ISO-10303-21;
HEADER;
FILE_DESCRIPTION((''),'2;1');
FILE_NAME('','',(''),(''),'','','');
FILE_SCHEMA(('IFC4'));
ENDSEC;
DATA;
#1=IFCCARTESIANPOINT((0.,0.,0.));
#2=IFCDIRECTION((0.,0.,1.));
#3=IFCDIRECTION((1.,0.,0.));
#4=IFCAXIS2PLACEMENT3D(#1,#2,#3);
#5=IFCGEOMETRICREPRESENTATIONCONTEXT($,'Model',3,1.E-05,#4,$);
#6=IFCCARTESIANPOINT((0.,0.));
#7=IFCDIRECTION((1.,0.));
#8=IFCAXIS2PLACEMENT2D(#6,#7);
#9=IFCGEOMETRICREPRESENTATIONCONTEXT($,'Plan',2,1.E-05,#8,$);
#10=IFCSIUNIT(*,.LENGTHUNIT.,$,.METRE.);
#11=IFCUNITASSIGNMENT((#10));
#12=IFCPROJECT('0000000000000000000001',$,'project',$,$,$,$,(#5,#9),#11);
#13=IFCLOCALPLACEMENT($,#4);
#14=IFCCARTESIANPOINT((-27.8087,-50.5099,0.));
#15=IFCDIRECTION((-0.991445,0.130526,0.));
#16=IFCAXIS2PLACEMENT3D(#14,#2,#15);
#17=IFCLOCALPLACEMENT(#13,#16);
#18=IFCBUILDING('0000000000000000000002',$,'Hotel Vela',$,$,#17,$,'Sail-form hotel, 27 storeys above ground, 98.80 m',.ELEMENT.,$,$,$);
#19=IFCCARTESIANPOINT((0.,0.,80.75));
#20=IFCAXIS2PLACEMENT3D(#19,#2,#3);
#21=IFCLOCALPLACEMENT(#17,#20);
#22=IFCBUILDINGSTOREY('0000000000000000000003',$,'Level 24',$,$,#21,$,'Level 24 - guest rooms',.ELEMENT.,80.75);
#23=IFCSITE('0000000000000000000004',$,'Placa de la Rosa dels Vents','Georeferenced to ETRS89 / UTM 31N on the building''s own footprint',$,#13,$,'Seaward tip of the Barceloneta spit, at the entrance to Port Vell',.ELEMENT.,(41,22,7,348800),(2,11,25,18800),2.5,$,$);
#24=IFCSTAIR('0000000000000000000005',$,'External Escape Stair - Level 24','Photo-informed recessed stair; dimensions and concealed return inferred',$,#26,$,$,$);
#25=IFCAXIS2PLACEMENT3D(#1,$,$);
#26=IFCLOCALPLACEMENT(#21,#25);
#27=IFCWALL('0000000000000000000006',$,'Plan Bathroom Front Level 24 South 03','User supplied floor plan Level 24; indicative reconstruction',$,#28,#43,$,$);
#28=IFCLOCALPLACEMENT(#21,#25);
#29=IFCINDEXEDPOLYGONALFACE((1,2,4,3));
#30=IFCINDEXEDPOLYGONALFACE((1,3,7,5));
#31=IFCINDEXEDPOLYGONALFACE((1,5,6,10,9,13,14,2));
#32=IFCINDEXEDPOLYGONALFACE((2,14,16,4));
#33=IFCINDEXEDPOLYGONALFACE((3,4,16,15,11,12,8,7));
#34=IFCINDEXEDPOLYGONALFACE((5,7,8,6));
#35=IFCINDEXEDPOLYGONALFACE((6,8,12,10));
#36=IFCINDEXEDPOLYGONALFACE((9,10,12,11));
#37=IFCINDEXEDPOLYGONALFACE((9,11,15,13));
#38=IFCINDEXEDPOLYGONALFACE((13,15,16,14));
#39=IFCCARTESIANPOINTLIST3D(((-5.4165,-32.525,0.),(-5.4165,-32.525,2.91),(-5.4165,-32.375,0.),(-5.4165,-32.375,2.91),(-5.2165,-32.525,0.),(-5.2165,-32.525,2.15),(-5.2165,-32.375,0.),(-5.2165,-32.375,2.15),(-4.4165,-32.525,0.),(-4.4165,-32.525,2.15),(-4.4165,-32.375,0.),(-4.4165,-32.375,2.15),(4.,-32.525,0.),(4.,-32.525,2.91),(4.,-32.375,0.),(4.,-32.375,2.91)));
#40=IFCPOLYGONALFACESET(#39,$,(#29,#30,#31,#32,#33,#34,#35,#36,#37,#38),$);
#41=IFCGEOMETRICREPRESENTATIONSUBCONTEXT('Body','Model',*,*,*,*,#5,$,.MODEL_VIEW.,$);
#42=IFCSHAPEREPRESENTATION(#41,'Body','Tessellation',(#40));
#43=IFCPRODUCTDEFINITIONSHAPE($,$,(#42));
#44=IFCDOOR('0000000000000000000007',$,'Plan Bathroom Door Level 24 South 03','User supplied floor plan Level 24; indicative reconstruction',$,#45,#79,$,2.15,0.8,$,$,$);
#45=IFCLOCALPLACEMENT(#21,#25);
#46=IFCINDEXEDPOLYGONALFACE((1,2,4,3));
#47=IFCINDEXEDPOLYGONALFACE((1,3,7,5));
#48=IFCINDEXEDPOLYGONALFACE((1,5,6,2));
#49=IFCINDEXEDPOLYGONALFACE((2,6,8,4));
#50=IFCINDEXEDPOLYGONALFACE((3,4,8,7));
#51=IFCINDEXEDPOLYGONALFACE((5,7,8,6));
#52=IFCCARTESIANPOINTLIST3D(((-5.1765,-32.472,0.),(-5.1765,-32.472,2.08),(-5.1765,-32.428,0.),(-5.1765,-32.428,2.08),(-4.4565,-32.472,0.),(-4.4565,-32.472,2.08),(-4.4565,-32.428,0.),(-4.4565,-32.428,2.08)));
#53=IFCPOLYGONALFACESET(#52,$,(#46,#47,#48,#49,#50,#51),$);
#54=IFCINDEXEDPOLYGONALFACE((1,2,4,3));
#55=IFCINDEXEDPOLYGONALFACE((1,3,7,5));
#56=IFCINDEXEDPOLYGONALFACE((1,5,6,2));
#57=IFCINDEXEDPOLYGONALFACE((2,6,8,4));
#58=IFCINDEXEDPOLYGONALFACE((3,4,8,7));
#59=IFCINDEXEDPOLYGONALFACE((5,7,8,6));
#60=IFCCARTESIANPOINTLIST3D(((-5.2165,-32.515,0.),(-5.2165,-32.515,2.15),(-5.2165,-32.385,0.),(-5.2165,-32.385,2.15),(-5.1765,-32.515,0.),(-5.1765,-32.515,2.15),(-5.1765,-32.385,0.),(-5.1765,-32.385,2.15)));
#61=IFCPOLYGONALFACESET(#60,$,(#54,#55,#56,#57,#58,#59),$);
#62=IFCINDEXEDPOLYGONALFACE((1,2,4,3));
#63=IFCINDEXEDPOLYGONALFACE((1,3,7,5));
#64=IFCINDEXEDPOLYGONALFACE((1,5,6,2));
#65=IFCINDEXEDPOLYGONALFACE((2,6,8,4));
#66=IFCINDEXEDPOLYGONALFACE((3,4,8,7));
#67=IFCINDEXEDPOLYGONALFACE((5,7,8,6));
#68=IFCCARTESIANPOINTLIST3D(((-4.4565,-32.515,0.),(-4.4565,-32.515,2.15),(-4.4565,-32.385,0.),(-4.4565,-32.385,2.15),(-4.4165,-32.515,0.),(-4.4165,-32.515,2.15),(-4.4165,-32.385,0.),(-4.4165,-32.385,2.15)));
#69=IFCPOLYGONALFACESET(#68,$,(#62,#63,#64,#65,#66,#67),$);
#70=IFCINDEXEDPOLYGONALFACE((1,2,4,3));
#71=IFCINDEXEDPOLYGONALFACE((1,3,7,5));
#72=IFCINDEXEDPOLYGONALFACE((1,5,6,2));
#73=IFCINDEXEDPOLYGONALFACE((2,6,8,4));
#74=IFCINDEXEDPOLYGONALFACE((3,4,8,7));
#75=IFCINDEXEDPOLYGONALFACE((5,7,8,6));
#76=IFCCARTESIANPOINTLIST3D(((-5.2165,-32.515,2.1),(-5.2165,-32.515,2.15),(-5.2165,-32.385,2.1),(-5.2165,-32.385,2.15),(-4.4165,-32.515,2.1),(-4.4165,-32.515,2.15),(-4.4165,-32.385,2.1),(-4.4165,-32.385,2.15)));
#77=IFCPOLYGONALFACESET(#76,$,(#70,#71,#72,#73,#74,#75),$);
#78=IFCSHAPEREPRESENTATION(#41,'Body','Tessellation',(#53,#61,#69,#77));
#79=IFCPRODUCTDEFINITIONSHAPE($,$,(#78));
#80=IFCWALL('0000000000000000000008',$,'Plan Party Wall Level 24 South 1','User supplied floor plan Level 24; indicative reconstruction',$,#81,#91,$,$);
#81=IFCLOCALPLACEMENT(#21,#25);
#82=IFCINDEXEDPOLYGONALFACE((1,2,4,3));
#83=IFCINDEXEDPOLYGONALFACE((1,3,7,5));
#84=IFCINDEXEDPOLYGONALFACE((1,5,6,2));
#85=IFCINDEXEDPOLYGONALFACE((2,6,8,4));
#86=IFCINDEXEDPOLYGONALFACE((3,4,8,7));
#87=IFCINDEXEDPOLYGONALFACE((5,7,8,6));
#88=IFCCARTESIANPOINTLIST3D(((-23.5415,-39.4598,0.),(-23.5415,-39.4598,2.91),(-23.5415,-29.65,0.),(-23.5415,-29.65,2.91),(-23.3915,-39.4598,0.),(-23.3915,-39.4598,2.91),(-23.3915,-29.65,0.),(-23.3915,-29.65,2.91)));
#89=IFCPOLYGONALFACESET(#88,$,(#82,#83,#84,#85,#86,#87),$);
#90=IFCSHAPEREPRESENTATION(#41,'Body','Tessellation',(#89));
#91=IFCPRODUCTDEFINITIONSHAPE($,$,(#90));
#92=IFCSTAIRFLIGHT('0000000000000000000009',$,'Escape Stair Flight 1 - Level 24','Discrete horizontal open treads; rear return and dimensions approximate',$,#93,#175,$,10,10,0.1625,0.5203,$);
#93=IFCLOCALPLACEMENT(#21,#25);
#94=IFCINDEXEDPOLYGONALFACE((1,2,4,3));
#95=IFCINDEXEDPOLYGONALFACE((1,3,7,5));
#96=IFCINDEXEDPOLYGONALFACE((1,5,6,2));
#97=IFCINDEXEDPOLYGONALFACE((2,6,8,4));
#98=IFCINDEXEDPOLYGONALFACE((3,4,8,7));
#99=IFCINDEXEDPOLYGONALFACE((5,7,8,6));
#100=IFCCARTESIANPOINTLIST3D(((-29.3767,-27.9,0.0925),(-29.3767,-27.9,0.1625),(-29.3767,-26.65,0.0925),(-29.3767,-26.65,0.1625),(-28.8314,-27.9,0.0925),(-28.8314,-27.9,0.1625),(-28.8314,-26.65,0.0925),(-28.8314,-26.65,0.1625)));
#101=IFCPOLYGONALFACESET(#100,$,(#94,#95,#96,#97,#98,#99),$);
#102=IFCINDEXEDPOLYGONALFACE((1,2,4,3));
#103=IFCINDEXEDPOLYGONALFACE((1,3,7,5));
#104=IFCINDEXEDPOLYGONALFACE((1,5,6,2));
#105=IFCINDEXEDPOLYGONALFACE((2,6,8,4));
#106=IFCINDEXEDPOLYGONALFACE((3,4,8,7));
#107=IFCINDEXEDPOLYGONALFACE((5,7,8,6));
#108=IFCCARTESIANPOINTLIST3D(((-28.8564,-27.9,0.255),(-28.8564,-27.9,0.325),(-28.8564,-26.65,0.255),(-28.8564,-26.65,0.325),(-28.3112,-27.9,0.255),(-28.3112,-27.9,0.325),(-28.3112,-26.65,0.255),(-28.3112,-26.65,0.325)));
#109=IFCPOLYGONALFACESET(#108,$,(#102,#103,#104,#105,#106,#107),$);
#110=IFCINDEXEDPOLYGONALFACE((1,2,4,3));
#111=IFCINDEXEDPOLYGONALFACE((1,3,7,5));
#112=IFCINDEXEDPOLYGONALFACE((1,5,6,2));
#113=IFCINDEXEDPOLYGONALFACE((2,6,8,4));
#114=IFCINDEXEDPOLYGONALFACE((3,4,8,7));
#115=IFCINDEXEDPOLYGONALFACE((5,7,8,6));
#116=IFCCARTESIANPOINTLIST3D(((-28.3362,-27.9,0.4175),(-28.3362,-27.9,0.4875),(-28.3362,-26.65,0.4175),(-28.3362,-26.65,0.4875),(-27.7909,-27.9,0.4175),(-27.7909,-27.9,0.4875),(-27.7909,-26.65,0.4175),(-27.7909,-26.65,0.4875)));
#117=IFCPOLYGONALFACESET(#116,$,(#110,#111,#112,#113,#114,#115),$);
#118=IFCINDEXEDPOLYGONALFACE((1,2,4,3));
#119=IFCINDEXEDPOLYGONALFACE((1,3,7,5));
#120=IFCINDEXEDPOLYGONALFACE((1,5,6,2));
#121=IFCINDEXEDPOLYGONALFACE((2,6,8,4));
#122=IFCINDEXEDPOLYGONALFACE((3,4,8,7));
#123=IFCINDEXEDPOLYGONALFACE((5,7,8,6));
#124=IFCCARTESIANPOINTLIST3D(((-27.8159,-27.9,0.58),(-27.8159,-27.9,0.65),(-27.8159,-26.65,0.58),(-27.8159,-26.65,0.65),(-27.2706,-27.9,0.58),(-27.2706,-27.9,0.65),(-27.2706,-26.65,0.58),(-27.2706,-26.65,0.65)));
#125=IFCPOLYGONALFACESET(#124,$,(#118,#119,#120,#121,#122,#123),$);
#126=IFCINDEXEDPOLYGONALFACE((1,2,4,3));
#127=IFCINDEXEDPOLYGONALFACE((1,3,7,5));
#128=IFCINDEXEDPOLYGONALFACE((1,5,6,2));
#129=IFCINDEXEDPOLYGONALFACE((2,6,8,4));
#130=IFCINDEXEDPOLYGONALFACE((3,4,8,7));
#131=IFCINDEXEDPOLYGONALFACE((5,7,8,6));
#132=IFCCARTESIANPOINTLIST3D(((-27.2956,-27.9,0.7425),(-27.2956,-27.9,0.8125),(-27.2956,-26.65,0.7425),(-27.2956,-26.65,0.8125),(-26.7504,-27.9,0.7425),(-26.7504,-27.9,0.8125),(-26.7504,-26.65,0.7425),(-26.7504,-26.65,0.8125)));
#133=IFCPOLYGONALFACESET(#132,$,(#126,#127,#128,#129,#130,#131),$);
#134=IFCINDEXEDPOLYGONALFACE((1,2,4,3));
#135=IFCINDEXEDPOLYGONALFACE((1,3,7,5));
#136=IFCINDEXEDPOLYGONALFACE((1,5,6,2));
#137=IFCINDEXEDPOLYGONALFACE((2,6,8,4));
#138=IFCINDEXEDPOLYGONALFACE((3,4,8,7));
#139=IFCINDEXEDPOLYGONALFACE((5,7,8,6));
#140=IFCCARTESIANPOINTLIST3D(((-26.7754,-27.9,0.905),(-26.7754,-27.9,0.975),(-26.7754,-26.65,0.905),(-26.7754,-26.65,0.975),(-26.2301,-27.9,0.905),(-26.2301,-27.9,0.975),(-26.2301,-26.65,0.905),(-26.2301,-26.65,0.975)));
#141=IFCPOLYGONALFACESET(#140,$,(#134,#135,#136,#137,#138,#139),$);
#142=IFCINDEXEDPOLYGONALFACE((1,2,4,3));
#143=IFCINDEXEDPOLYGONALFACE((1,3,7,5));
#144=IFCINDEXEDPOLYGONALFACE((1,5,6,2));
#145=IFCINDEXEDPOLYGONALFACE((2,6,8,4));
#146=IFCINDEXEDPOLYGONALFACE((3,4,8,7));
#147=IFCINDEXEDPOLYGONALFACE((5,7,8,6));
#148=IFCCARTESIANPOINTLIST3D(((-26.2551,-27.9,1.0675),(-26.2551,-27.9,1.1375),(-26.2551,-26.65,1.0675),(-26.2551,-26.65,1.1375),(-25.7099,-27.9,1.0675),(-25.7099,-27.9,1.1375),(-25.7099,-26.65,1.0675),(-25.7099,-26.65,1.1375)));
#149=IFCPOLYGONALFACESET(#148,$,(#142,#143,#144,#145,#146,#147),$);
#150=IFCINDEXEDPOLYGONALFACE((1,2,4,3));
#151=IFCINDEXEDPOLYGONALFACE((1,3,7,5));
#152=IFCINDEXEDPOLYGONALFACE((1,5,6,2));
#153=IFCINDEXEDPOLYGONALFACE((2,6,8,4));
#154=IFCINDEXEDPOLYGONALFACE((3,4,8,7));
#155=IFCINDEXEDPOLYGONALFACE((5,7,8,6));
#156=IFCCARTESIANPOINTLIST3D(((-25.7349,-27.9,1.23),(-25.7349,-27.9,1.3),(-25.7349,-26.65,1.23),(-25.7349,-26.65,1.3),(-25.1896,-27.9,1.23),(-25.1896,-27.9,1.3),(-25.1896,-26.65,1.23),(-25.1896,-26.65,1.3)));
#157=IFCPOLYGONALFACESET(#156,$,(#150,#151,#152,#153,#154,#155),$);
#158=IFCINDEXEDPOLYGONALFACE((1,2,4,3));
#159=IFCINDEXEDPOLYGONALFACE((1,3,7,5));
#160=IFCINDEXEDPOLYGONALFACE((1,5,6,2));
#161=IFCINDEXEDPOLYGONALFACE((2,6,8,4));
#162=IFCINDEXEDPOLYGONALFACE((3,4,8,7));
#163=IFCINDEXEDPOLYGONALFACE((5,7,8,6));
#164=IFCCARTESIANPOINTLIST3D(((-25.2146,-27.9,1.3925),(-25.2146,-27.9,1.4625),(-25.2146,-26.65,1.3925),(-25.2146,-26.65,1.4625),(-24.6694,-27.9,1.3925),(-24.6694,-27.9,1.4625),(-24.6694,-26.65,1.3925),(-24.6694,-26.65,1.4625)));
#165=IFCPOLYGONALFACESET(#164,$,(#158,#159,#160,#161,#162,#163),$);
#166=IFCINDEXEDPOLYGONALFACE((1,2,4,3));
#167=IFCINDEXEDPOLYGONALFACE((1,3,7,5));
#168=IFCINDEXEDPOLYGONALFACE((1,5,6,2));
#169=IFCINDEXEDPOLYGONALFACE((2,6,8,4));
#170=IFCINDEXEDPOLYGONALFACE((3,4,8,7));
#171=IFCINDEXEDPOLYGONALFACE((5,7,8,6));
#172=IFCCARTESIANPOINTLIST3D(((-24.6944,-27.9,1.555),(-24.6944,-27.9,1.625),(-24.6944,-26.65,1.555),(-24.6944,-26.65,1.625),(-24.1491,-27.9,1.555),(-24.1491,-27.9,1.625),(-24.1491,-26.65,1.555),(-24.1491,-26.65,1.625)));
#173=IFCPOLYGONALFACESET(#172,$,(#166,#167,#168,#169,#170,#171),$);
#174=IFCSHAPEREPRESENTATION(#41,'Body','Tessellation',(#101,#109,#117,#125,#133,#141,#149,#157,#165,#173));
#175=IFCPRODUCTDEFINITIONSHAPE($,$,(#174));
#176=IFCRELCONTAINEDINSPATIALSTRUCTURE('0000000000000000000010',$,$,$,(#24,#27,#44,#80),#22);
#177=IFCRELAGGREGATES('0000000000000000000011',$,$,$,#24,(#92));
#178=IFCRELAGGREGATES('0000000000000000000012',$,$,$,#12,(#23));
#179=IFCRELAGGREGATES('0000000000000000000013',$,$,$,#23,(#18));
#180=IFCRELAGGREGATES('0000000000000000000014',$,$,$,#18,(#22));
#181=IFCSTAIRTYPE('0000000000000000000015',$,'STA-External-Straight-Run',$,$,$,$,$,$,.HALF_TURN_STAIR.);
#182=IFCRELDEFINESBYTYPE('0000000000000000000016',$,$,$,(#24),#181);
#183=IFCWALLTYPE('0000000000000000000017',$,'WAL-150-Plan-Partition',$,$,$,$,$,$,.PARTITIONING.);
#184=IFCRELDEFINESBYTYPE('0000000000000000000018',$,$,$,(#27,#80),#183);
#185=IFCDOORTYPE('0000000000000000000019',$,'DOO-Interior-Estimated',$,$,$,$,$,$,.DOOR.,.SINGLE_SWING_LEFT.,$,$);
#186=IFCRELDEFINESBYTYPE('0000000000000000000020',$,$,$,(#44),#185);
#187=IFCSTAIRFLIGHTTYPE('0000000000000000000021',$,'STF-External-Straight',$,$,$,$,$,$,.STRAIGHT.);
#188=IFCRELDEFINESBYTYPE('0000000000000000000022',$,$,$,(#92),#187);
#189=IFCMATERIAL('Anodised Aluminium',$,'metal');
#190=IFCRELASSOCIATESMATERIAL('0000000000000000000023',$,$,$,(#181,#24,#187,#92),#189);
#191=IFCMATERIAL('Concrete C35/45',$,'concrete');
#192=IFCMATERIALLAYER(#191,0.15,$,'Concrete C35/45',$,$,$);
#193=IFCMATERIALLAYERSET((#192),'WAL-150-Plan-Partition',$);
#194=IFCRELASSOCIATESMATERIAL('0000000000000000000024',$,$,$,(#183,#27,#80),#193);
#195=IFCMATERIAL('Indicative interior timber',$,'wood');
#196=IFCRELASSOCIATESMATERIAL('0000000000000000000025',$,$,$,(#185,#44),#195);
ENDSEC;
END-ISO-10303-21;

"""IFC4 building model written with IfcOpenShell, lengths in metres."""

from ifc_helpers import new_model, si_unit, frame, origin_with_axes, origin_2d_with_axis, place, context, subcontext, project, spatial, line, indexed_curve, outline, extrude, material, layer, layer_set, layer_usage, type_object, element, fill, aggregate, save


model = new_model("IFC4")

# Units and contexts
model_context = context("Model", 3, precision=1e-05, world=origin_with_axes())
plan_context = context("Plan", 2, precision=1e-05, world=origin_2d_with_axis())
body_context = subcontext(model_context, "Body", "Model", "MODEL_VIEW")
ifc_project = project(units=[si_unit("LENGTHUNIT", "METRE")], contexts=[model_context, plan_context])

# Site, building, storey
site_placement = place(None, origin_with_axes())
site = spatial("IfcSite", under=ifc_project, at=site_placement, Name="Placa de la Rosa dels Vents", Description="Georeferenced to ETRS89 / UTM 31N on the building's own footprint", LongName="Seaward tip of the Barceloneta spit, at the entrance to Port Vell", CompositionType="ELEMENT", RefLatitude=(41, 22, 7, 348800), RefLongitude=(2, 11, 25, 18800), RefElevation=2.5)
building_placement = place(site_placement, frame((-27.8087, -50.5099, 0.0), z_axis=(0.0, 0.0, 1.0), x_axis=(-0.991445, 0.130526, 0.0)))
building = spatial("IfcBuilding", under=site, at=building_placement, Name="Hotel Vela", LongName="Sail-form hotel, 27 storeys above ground, 98.80 m", CompositionType="ELEMENT")
storey_placement = place(building_placement, frame((0.0, 0.0, 80.75), z_axis=(0.0, 0.0, 1.0), x_axis=(1.0, 0.0, 0.0)))
storey = spatial("IfcBuildingStorey", under=building, at=storey_placement, Name="Level 24", LongName="Level 24 - guest rooms", CompositionType="ELEMENT", Elevation=80.75)

# Stair
ifc_material_1 = material(Name="Anodised Aluminium", Category="metal")
stair_type = type_object("IfcStairType", Name="STA-External-Straight-Run", PredefinedType="HALF_TURN_STAIR", material=ifc_material_1)
stair_placement = place(storey_placement, frame((0.0, 0.0, -80.75), z_axis=(0.0, 0.0, 1.0), x_axis=(1.0, 0.0, 0.0)))
stair = element("IfcStair", 1, at=stair_placement, inside=storey, type_object=stair_type, material=ifc_material_1, Name="External Escape Stair - Level 24", Description="Photo-informed recessed stair; dimensions and concealed return inferred")

# Shared definitions
ifc_material_2 = material(Name="Concrete C35/45", Category="concrete")

# Shared definitions
ifc_layer_1 = layer(ifc_material_2, 0.15, Name="Concrete C35/45")
ifc_layer_set_1 = layer_set([ifc_layer_1], Name="WAL-150-Plan-Partition")
wall_type = type_object("IfcWallType", Name="WAL-150-Plan-Partition", PredefinedType="PARTITIONING", material=ifc_layer_set_1)
ifc_material_3 = material(Name="Indicative interior timber", Category="wood")
door_type = type_object("IfcDoorType", Name="DOO-Interior-Estimated", OperationType="SINGLE_SWING_LEFT", PredefinedType="DOOR", material=ifc_material_3)

# Wall, opening, door
ifc_layer_usage_1 = layer_usage(ifc_layer_set_1, "AXIS2", "POSITIVE", 0.0)
wall_1_placement = place(storey_placement, frame((-5.4165, -32.525, 0.0), z_axis=(0.0, 0.0, 1.0), x_axis=(1.0, 0.0, 0.0)))
wall_1 = element("IfcWall", 2, at=wall_1_placement, inside=storey, type_object=wall_type, material=ifc_layer_usage_1, Name="Plan Bathroom Front Level 24 South 03", Description="User supplied floor plan Level 24; indicative reconstruction", context=body_context, shape_type="SweptSolid", body=[
    extrude(outline(indexed_curve([(0.0, 0.0), (9.4165, 0.0), (9.4165, 0.15), (0.0, 0.15)], segments=[line(1, 2, 3, 4, 1)])), origin_with_axes(), (0.0, 0.0, 1.0), 2.91),
])
opening_1_placement = place(wall_1_placement, frame((0.2, -0.085, 0.0), z_axis=(0.0, 0.0, 1.0), x_axis=(1.0, 0.0, 0.0)))
opening_1 = element("IfcOpeningElement", 3, at=opening_1_placement, cuts=wall_1, PredefinedType="OPENING", context=body_context, shape_type="SweptSolid", body=[
    extrude(outline(indexed_curve([(0.0, 0.0), (0.8, 0.0), (0.8, 0.32), (0.0, 0.32)], segments=[line(1, 2, 3, 4, 1)])), origin_with_axes(), (0.0, 0.0, 1.0), 2.15),
])
door_1_placement = place(storey_placement, frame((0.0, 0.0, -80.75), z_axis=(0.0, 0.0, 1.0), x_axis=(1.0, 0.0, 0.0)))
door_1 = element("IfcDoor", 4, at=door_1_placement, inside=storey, type_object=door_type, material=ifc_material_3, Name="Plan Bathroom Door Level 24 South 03", Description="User supplied floor plan Level 24; indicative reconstruction", OverallHeight=2.15, OverallWidth=0.8, context=body_context, shape_type="SweptSolid", body=[
    extrude(outline(indexed_curve([(0.0, 0.0), (0.72, 0.0), (0.72, 0.044), (0.0, 0.044)], segments=[line(1, 2, 3, 4, 1)])), frame((-5.1765, -32.472, 80.75), z_axis=(0.0, 0.0, 1.0), x_axis=(1.0, 0.0, 0.0)), (0.0, 0.0, 1.0), 2.08),
    extrude(outline(indexed_curve([(0.0, 0.0), (0.04, 0.0), (0.04, 0.13), (0.0, 0.13)], segments=[line(1, 2, 3, 4, 1)])), frame((-5.2165, -32.515, 80.75), z_axis=(0.0, 0.0, 1.0), x_axis=(1.0, 0.0, 0.0)), (0.0, 0.0, 1.0), 2.15),
    extrude(outline(indexed_curve([(0.0, 0.0), (0.04, 0.0), (0.04, 0.13), (0.0, 0.13)], segments=[line(1, 2, 3, 4, 1)])), frame((-4.4565, -32.515, 80.75), z_axis=(0.0, 0.0, 1.0), x_axis=(1.0, 0.0, 0.0)), (0.0, 0.0, 1.0), 2.15),
    extrude(outline(indexed_curve([(0.0, 0.0), (0.8, 0.0), (0.8, 0.13), (0.0, 0.13)], segments=[line(1, 2, 3, 4, 1)])), frame((-5.2165, -32.515, 82.85), z_axis=(0.0, 0.0, 1.0), x_axis=(1.0, 0.0, 0.0)), (0.0, 0.0, 1.0), 0.05),
])
fill(opening_1, door_1)

# Wall
ifc_layer_usage_2 = layer_usage(ifc_layer_set_1, "AXIS2", "POSITIVE", 0.0)
wall_2_placement = place(storey_placement, frame((-23.5415, -39.4598, 0.0), z_axis=(0.0, 0.0, 1.0), x_axis=(1.0, 0.0, 0.0)))
element("IfcWall", 5, at=wall_2_placement, inside=storey, type_object=wall_type, material=ifc_layer_usage_2, Name="Plan Party Wall Level 24 South 1", Description="User supplied floor plan Level 24; indicative reconstruction", context=body_context, shape_type="SweptSolid", body=[
    extrude(outline(indexed_curve([(0.0, 0.0), (0.15, 0.0), (0.15, 9.8098), (0.0, 9.8098)], segments=[line(1, 2, 3, 4, 1)])), origin_with_axes(), (0.0, 0.0, 1.0), 2.91),
])

# Stair flight
stair_flight_type = type_object("IfcStairFlightType", Name="STF-External-Straight", PredefinedType="STRAIGHT", material=ifc_material_1)
stair_flight_1_placement = place(stair_placement, origin_with_axes())
stair_flight_1 = element("IfcStairFlight", 6, at=stair_flight_1_placement, type_object=stair_flight_type, material=ifc_material_1, Name="Escape Stair Flight 1 - Level 24", Description="Discrete horizontal open treads; rear return and dimensions approximate", NumberOfRisers=10, NumberOfTreads=10, RiserHeight=0.1625, TreadLength=0.5203, context=body_context, shape_type="SweptSolid", body=[
    extrude(outline(indexed_curve([(0.0, 0.0), (0.5453, 0.0), (0.5453, 1.25), (0.0, 1.25)], segments=[line(1, 2, 3, 4, 1)])), frame((-29.3767, -27.9, 80.8425), z_axis=(0.0, 0.0, 1.0), x_axis=(1.0, 0.0, 0.0)), (0.0, 0.0, 1.0), 0.07),
    extrude(outline(indexed_curve([(0.0, 0.0), (0.5453, 0.0), (0.5453, 1.25), (0.0, 1.25)], segments=[line(1, 2, 3, 4, 1)])), frame((-28.8564, -27.9, 81.005), z_axis=(0.0, 0.0, 1.0), x_axis=(1.0, 0.0, 0.0)), (0.0, 0.0, 1.0), 0.07),
    extrude(outline(indexed_curve([(0.0, 0.0), (0.5453, 0.0), (0.5453, 1.25), (0.0, 1.25)], segments=[line(1, 2, 3, 4, 1)])), frame((-28.3362, -27.9, 81.1675), z_axis=(0.0, 0.0, 1.0), x_axis=(1.0, 0.0, 0.0)), (0.0, 0.0, 1.0), 0.07),
    extrude(outline(indexed_curve([(0.0, 0.0), (0.5453, 0.0), (0.5453, 1.25), (0.0, 1.25)], segments=[line(1, 2, 3, 4, 1)])), frame((-27.8159, -27.9, 81.33), z_axis=(0.0, 0.0, 1.0), x_axis=(1.0, 0.0, 0.0)), (0.0, 0.0, 1.0), 0.07),
    extrude(outline(indexed_curve([(0.0, 0.0), (0.5453, 0.0), (0.5453, 1.25), (0.0, 1.25)], segments=[line(1, 2, 3, 4, 1)])), frame((-27.2956, -27.9, 81.4925), z_axis=(0.0, 0.0, 1.0), x_axis=(1.0, 0.0, 0.0)), (0.0, 0.0, 1.0), 0.07),
    extrude(outline(indexed_curve([(0.0, 0.0), (0.5453, 0.0), (0.5453, 1.25), (0.0, 1.25)], segments=[line(1, 2, 3, 4, 1)])), frame((-26.7754, -27.9, 81.655), z_axis=(0.0, 0.0, 1.0), x_axis=(1.0, 0.0, 0.0)), (0.0, 0.0, 1.0), 0.07),
    extrude(outline(indexed_curve([(0.0, 0.0), (0.5453, 0.0), (0.5453, 1.25), (0.0, 1.25)], segments=[line(1, 2, 3, 4, 1)])), frame((-26.2551, -27.9, 81.8175), z_axis=(0.0, 0.0, 1.0), x_axis=(1.0, 0.0, 0.0)), (0.0, 0.0, 1.0), 0.07),
    extrude(outline(indexed_curve([(0.0, 0.0), (0.5453, 0.0), (0.5453, 1.25), (0.0, 1.25)], segments=[line(1, 2, 3, 4, 1)])), frame((-25.7349, -27.9, 81.98), z_axis=(0.0, 0.0, 1.0), x_axis=(1.0, 0.0, 0.0)), (0.0, 0.0, 1.0), 0.07),
    extrude(outline(indexed_curve([(0.0, 0.0), (0.5453, 0.0), (0.5453, 1.25), (0.0, 1.25)], segments=[line(1, 2, 3, 4, 1)])), frame((-25.2146, -27.9, 82.1425), z_axis=(0.0, 0.0, 1.0), x_axis=(1.0, 0.0, 0.0)), (0.0, 0.0, 1.0), 0.07),
    extrude(outline(indexed_curve([(0.0, 0.0), (0.5453, 0.0), (0.5453, 1.25), (0.0, 1.25)], segments=[line(1, 2, 3, 4, 1)])), frame((-24.6944, -27.9, 82.305), z_axis=(0.0, 0.0, 1.0), x_axis=(1.0, 0.0, 0.0)), (0.0, 0.0, 1.0), 0.07),
])

aggregate(stair, [stair_flight_1])

save(model, "model.ifc")
